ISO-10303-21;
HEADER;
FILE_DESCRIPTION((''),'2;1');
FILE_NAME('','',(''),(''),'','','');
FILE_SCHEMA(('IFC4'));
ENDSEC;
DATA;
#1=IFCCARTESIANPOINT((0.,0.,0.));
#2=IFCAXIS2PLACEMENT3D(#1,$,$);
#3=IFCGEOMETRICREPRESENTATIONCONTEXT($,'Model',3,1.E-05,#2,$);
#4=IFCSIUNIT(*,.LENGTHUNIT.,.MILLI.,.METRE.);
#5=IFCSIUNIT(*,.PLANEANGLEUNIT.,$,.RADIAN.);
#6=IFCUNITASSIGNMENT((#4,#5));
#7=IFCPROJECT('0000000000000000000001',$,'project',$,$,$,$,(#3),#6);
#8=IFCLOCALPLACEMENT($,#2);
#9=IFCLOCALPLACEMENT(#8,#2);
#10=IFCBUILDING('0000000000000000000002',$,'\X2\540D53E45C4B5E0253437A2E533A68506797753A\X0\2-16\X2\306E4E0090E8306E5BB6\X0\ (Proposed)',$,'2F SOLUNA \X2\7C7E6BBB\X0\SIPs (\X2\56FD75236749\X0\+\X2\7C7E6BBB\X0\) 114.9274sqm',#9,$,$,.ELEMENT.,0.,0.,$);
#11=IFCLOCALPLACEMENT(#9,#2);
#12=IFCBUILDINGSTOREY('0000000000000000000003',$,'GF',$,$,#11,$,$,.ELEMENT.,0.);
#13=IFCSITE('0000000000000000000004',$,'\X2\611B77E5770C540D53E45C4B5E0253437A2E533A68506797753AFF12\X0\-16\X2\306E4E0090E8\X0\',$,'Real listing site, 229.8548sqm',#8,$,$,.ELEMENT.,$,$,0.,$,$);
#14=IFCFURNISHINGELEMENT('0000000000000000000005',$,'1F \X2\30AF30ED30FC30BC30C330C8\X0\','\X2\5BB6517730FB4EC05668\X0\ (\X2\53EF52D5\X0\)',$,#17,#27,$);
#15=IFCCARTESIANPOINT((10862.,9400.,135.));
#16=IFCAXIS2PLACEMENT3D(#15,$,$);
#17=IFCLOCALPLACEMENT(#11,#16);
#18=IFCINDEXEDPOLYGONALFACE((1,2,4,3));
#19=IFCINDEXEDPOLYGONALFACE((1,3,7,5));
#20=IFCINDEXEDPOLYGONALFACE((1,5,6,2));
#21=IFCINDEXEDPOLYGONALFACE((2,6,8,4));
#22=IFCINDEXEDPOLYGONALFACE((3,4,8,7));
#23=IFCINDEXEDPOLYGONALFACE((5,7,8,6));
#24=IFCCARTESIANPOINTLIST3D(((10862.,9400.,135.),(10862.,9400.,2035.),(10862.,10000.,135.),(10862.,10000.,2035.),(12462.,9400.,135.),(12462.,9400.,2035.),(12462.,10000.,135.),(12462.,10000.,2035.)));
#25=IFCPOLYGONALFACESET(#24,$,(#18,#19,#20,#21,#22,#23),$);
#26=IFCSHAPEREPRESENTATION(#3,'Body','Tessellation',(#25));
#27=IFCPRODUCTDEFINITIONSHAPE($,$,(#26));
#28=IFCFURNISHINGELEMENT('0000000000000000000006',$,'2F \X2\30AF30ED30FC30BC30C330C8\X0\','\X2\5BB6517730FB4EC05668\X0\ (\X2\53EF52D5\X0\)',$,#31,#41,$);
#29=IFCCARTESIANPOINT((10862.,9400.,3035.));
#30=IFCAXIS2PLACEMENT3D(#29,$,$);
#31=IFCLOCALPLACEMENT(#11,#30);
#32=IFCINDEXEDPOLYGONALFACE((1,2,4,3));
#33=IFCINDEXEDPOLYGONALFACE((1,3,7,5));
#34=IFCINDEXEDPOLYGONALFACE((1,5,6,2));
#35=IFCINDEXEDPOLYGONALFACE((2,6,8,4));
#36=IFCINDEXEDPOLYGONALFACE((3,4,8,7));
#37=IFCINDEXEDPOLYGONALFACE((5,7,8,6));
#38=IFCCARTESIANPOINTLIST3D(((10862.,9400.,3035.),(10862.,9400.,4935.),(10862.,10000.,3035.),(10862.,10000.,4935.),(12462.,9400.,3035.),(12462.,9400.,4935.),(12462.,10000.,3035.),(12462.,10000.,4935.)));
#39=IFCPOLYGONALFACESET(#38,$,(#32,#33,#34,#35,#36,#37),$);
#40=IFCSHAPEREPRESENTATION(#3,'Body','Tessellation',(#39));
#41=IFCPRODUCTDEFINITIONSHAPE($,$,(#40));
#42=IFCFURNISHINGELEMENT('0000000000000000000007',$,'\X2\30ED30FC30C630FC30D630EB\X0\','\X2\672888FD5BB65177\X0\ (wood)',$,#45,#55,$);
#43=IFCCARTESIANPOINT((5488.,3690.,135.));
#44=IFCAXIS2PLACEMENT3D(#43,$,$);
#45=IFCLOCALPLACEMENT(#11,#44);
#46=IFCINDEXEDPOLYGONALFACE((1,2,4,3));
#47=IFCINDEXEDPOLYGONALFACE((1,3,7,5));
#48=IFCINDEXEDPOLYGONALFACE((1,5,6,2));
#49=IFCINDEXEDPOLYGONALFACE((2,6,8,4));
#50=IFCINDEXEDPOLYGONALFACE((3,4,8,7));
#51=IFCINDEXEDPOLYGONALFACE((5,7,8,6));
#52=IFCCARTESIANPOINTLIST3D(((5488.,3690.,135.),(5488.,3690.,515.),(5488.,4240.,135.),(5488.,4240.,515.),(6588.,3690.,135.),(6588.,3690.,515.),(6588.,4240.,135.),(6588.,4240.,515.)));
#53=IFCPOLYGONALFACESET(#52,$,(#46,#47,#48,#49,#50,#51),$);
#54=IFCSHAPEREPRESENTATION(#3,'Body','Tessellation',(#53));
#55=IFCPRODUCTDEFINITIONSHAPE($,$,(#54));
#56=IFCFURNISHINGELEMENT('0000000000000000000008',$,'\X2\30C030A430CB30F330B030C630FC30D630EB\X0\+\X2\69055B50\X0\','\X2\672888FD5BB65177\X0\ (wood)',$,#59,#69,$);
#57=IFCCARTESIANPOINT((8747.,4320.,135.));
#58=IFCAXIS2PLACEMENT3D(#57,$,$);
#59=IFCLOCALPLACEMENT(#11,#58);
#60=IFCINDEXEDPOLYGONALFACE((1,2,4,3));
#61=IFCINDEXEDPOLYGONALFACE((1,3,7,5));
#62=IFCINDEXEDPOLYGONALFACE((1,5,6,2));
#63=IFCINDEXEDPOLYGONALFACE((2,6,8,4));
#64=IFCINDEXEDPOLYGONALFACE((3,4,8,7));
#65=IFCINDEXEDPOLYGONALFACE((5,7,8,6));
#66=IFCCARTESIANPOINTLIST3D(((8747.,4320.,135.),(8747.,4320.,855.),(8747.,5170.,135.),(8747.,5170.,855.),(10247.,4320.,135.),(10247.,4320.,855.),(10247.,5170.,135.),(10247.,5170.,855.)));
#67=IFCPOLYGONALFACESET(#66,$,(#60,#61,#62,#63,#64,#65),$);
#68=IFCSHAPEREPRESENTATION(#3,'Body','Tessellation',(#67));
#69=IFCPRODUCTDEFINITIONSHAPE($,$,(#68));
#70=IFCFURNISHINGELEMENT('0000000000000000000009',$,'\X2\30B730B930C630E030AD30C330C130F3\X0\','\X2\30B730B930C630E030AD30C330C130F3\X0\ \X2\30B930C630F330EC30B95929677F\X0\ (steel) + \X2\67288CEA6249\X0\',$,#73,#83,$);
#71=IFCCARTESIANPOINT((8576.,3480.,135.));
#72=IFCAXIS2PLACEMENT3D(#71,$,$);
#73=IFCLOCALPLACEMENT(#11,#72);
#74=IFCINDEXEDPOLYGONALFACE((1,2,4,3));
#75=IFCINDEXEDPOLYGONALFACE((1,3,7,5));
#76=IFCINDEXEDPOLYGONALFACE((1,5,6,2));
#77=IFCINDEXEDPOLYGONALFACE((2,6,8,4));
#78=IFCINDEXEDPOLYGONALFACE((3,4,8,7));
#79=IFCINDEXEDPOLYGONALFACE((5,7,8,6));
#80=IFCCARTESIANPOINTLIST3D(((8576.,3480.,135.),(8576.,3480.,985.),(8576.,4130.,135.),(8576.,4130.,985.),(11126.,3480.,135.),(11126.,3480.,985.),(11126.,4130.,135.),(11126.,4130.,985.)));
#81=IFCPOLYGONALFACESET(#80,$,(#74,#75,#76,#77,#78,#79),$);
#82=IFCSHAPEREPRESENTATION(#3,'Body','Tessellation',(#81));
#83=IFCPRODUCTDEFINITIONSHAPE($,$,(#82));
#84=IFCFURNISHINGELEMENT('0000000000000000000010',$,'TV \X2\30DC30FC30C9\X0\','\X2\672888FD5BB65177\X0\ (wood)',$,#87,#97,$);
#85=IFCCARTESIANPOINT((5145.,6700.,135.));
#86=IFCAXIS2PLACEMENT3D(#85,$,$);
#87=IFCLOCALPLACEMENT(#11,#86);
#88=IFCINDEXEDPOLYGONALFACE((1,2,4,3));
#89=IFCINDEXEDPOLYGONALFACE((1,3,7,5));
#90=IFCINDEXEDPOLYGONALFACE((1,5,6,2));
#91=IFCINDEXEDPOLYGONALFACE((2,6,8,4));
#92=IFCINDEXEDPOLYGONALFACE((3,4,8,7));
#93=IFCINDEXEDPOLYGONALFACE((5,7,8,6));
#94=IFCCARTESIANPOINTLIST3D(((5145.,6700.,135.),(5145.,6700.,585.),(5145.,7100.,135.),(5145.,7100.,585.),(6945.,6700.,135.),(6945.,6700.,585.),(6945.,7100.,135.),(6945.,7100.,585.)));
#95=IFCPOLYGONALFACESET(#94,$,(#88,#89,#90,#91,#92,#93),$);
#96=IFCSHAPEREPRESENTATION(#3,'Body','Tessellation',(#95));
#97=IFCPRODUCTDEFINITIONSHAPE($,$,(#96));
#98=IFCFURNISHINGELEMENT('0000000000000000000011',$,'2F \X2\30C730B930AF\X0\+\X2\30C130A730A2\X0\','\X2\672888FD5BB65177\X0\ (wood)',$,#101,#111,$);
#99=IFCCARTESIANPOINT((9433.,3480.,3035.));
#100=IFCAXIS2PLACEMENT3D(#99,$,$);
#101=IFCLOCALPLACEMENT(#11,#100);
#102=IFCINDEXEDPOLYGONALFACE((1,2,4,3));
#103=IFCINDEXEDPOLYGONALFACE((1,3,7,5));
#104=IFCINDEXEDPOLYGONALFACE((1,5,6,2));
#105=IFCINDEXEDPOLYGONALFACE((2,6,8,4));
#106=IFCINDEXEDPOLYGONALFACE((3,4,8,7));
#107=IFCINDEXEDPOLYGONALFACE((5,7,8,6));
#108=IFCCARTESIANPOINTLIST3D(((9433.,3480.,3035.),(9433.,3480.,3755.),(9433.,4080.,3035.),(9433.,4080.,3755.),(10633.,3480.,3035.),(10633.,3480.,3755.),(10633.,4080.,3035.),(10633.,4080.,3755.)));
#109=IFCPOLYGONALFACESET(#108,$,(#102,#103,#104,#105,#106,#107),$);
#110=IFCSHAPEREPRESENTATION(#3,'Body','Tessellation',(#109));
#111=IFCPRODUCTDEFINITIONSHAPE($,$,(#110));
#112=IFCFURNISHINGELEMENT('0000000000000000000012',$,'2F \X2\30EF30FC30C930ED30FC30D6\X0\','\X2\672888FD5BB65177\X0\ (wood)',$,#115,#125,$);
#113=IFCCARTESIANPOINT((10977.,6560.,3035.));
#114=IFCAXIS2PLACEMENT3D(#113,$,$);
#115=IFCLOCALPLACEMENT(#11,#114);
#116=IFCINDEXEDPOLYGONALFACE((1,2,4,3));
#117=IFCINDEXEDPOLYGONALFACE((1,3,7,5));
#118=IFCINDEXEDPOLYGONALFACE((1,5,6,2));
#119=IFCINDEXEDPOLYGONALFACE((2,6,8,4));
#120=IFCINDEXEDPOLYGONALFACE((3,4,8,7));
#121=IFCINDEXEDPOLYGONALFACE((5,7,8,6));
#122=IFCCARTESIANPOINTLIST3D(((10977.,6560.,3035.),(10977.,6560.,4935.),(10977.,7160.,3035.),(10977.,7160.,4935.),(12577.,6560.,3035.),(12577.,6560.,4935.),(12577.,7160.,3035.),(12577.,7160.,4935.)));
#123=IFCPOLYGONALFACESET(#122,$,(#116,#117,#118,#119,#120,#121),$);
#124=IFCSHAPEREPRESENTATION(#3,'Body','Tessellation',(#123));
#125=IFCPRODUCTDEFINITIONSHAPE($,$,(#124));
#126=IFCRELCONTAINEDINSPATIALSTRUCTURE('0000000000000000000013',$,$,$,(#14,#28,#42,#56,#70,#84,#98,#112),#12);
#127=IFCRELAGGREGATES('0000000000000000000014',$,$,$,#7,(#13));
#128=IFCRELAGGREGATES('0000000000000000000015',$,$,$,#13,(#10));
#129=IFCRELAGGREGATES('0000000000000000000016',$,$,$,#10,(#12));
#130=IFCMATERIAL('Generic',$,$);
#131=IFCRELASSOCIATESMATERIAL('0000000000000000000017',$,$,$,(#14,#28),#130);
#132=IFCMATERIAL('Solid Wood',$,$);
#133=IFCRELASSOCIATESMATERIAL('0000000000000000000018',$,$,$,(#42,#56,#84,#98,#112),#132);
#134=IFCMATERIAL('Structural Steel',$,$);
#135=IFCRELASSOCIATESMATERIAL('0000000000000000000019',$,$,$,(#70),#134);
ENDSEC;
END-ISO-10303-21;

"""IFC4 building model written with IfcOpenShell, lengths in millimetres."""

from ifc_helpers import new_model, si_unit, frame, frame_2d, origin, place, context, project, spatial, rectangle, extrude, material, element, save


model = new_model("IFC4")

# Units and contexts
model_context = context("Model", 3, precision=1e-05, world=origin())
ifc_project = project(units=[si_unit("LENGTHUNIT", "METRE", prefix="MILLI"), si_unit("PLANEANGLEUNIT", "RADIAN")], contexts=[model_context])

# Site, building, storey
site_placement = place(None, origin())
site = spatial("IfcSite", under=ifc_project, at=site_placement, Name="愛知県名古屋市千種区桐林町２-16の一部", ObjectType="Real listing site, 229.8548sqm", CompositionType="ELEMENT", RefElevation=0.0)
building_placement = place(site_placement, origin())
building = spatial("IfcBuilding", under=site, at=building_placement, Name="名古屋市千種区桐林町2-16の一部の家 (Proposed)", ObjectType="2F SOLUNA 籾殻SIPs (国産杉+籾殻) 114.9274sqm", CompositionType="ELEMENT", ElevationOfRefHeight=0.0, ElevationOfTerrain=0.0)
storey_placement = place(building_placement, origin())
storey = spatial("IfcBuildingStorey", under=building, at=storey_placement, Name="GF", CompositionType="ELEMENT", Elevation=0.0)

# Shared definitions
ifc_material_1 = material(Name="Solid Wood")

# Shared definitions
ifc_material_2 = material(Name="Generic")

# Furnishing elements
furnishing_1_placement = place(storey_placement, frame((10862.0, 9400.0, 135.0)))
element("IfcFurnishingElement", 1, at=furnishing_1_placement, inside=storey, material=ifc_material_2, Name="1F クローゼット", Description="家具・什器 (可動)", context=model_context, shape_type="SweptSolid", body=[
    extrude(rectangle(XDim=1600.0, YDim=600.0, at=frame_2d((800.0, 300.0))), frame((10862.0, 9400.0, 135.0)), (0.0, 0.0, 1.0), 1900.0),
])
furnishing_2_placement = place(storey_placement, frame((10862.0, 9400.0, 3035.0)))
element("IfcFurnishingElement", 2, at=furnishing_2_placement, inside=storey, material=ifc_material_2, Name="2F クローゼット", Description="家具・什器 (可動)", context=model_context, shape_type="SweptSolid", body=[
    extrude(rectangle(XDim=1600.0, YDim=600.0, at=frame_2d((800.0, 300.0))), frame((10862.0, 9400.0, 3035.0)), (0.0, 0.0, 1.0), 1900.0),
])
furnishing_3_placement = place(storey_placement, frame((5488.0, 3690.0, 135.0)))
element("IfcFurnishingElement", 3, at=furnishing_3_placement, inside=storey, material=ifc_material_1, Name="ローテーブル", Description="木製家具 (wood)", context=model_context, shape_type="SweptSolid", body=[
    extrude(rectangle(XDim=1100.0, YDim=550.0, at=frame_2d((550.0, 275.0))), frame((5488.0, 3690.0, 135.0)), (0.0, 0.0, 1.0), 380.0),
])
furnishing_4_placement = place(storey_placement, frame((8747.0, 4320.0, 135.0)))
element("IfcFurnishingElement", 4, at=furnishing_4_placement, inside=storey, material=ifc_material_1, Name="ダイニングテーブル+椅子", Description="木製家具 (wood)", context=model_context, shape_type="SweptSolid", body=[
    extrude(rectangle(XDim=1500.0, YDim=850.0, at=frame_2d((750.0, 425.0))), frame((8747.0, 4320.0, 135.0)), (0.0, 0.0, 1.0), 720.0),
])
ifc_material_3 = material(Name="Structural Steel")
furnishing_5_placement = place(storey_placement, frame((8576.0, 3480.0, 135.0)))
element("IfcFurnishingElement", 5, at=furnishing_5_placement, inside=storey, material=ifc_material_3, Name="システムキッチン", Description="システムキッチン ステンレス天板 (steel) + 木質扉", context=model_context, shape_type="SweptSolid", body=[
    extrude(rectangle(XDim=2550.0, YDim=650.0, at=frame_2d((1275.0, 325.0))), frame((8576.0, 3480.0, 135.0)), (0.0, 0.0, 1.0), 850.0),
])
furnishing_6_placement = place(storey_placement, frame((5145.0, 6700.0, 135.0)))
element("IfcFurnishingElement", 6, at=furnishing_6_placement, inside=storey, material=ifc_material_1, Name="TV ボード", Description="木製家具 (wood)", context=model_context, shape_type="SweptSolid", body=[
    extrude(rectangle(XDim=1800.0, YDim=400.0, at=frame_2d((900.0, 200.0))), frame((5145.0, 6700.0, 135.0)), (0.0, 0.0, 1.0), 450.0),
])
furnishing_7_placement = place(storey_placement, frame((9433.0, 3480.0, 3035.0)))
element("IfcFurnishingElement", 7, at=furnishing_7_placement, inside=storey, material=ifc_material_1, Name="2F デスク+チェア", Description="木製家具 (wood)", context=model_context, shape_type="SweptSolid", body=[
    extrude(rectangle(XDim=1200.0, YDim=600.0, at=frame_2d((600.0, 300.0))), frame((9433.0, 3480.0, 3035.0)), (0.0, 0.0, 1.0), 720.0),
])
furnishing_8_placement = place(storey_placement, frame((10977.0, 6560.0, 3035.0)))
element("IfcFurnishingElement", 8, at=furnishing_8_placement, inside=storey, material=ifc_material_1, Name="2F ワードローブ", Description="木製家具 (wood)", context=model_context, shape_type="SweptSolid", body=[
    extrude(rectangle(XDim=1600.0, YDim=600.0, at=frame_2d((800.0, 300.0))), frame((10977.0, 6560.0, 3035.0)), (0.0, 0.0, 1.0), 1900.0),
])

save(model, "model.ifc")
